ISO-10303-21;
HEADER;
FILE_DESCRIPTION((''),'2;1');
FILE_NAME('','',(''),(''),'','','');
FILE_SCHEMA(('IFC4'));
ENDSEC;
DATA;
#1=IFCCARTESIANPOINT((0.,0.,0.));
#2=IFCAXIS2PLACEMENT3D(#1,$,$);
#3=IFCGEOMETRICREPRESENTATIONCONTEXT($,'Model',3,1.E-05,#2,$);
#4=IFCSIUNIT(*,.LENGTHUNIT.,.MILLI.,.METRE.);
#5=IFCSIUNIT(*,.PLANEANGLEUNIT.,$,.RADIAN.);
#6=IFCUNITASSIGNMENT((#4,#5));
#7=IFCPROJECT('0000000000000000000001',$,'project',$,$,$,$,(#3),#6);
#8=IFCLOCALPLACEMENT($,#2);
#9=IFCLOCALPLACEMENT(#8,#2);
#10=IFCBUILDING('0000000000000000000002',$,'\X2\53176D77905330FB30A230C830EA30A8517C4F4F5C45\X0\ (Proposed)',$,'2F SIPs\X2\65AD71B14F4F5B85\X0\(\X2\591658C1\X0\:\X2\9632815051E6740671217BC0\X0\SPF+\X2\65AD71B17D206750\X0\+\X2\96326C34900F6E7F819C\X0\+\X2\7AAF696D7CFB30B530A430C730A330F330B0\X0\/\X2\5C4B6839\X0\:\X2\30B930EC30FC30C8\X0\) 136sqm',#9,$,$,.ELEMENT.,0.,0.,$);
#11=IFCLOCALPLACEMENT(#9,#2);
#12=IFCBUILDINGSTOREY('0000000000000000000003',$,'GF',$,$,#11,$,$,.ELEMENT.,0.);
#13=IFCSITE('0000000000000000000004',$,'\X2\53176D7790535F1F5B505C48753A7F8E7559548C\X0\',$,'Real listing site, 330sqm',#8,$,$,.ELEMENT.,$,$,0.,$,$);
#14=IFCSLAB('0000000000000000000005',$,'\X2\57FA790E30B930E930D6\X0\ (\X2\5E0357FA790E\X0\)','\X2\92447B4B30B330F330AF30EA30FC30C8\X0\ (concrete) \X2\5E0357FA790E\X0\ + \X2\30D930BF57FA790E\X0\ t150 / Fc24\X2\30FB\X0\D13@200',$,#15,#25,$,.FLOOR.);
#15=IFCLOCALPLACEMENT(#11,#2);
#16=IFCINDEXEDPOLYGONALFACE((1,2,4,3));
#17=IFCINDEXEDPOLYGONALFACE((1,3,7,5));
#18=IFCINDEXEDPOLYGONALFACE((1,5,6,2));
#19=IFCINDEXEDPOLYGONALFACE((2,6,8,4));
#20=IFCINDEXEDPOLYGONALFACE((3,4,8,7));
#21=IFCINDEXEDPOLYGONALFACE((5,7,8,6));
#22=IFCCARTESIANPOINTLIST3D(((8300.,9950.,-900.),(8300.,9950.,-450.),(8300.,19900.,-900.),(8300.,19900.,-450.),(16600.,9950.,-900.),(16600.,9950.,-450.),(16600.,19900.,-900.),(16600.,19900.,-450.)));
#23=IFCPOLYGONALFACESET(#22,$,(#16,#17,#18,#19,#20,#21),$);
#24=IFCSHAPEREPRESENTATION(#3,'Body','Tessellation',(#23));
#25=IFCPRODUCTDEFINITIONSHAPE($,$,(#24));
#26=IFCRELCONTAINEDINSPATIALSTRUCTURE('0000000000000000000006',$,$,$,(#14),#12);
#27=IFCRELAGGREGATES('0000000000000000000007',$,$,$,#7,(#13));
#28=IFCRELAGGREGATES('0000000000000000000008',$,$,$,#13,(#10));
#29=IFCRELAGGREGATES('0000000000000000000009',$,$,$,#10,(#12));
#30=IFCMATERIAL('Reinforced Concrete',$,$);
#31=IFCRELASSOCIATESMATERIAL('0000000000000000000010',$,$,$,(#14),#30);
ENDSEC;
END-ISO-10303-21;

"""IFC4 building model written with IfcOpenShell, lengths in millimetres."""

from ifc_helpers import new_model, si_unit, frame, frame_2d, origin, place, context, project, spatial, rectangle, extrude, material, element, save


model = new_model("IFC4")

# Units and contexts
model_context = context("Model", 3, precision=1e-05, world=origin())
ifc_project = project(units=[si_unit("LENGTHUNIT", "METRE", prefix="MILLI"), si_unit("PLANEANGLEUNIT", "RADIAN")], contexts=[model_context])

# Site, building, storey
site_placement = place(None, origin())
site = spatial("IfcSite", under=ifc_project, at=site_placement, Name="北海道弟子屈町美留和", ObjectType="Real listing site, 330sqm", CompositionType="ELEMENT", RefElevation=0.0)
building_placement = place(site_placement, origin())
building = spatial("IfcBuilding", under=site, at=building_placement, Name="北海道・アトリエ兼住居 (Proposed)", ObjectType="2F SIPs断熱住宅(外壁:防腐処理無節SPF+断熱素材+防水透湿膜+窯業系サイディング/屋根:スレート) 136sqm", CompositionType="ELEMENT", ElevationOfRefHeight=0.0, ElevationOfTerrain=0.0)
storey_placement = place(building_placement, origin())
storey = spatial("IfcBuildingStorey", under=building, at=storey_placement, Name="GF", CompositionType="ELEMENT", Elevation=0.0)

# Slab
ifc_material_1 = material(Name="Reinforced Concrete")
slab_1_placement = place(storey_placement, frame((4150.0, 4975.0, -450.0)))
element("IfcSlab", 1, at=slab_1_placement, inside=storey, material=ifc_material_1, Name="基礎スラブ (布基礎)", Description="鉄筋コンクリート (concrete) 布基礎 + ベタ基礎 t150 / Fc24・D13@200", PredefinedType="FLOOR", context=model_context, shape_type="SweptSolid", body=[
    extrude(rectangle(XDim=8300.0, YDim=9950.0, at=frame_2d((4150.0, 4975.0))), frame((4150.0, 4975.0, -450.0)), (0.0, 0.0, 1.0), 450.0),
])

save(model, "model.ifc")
